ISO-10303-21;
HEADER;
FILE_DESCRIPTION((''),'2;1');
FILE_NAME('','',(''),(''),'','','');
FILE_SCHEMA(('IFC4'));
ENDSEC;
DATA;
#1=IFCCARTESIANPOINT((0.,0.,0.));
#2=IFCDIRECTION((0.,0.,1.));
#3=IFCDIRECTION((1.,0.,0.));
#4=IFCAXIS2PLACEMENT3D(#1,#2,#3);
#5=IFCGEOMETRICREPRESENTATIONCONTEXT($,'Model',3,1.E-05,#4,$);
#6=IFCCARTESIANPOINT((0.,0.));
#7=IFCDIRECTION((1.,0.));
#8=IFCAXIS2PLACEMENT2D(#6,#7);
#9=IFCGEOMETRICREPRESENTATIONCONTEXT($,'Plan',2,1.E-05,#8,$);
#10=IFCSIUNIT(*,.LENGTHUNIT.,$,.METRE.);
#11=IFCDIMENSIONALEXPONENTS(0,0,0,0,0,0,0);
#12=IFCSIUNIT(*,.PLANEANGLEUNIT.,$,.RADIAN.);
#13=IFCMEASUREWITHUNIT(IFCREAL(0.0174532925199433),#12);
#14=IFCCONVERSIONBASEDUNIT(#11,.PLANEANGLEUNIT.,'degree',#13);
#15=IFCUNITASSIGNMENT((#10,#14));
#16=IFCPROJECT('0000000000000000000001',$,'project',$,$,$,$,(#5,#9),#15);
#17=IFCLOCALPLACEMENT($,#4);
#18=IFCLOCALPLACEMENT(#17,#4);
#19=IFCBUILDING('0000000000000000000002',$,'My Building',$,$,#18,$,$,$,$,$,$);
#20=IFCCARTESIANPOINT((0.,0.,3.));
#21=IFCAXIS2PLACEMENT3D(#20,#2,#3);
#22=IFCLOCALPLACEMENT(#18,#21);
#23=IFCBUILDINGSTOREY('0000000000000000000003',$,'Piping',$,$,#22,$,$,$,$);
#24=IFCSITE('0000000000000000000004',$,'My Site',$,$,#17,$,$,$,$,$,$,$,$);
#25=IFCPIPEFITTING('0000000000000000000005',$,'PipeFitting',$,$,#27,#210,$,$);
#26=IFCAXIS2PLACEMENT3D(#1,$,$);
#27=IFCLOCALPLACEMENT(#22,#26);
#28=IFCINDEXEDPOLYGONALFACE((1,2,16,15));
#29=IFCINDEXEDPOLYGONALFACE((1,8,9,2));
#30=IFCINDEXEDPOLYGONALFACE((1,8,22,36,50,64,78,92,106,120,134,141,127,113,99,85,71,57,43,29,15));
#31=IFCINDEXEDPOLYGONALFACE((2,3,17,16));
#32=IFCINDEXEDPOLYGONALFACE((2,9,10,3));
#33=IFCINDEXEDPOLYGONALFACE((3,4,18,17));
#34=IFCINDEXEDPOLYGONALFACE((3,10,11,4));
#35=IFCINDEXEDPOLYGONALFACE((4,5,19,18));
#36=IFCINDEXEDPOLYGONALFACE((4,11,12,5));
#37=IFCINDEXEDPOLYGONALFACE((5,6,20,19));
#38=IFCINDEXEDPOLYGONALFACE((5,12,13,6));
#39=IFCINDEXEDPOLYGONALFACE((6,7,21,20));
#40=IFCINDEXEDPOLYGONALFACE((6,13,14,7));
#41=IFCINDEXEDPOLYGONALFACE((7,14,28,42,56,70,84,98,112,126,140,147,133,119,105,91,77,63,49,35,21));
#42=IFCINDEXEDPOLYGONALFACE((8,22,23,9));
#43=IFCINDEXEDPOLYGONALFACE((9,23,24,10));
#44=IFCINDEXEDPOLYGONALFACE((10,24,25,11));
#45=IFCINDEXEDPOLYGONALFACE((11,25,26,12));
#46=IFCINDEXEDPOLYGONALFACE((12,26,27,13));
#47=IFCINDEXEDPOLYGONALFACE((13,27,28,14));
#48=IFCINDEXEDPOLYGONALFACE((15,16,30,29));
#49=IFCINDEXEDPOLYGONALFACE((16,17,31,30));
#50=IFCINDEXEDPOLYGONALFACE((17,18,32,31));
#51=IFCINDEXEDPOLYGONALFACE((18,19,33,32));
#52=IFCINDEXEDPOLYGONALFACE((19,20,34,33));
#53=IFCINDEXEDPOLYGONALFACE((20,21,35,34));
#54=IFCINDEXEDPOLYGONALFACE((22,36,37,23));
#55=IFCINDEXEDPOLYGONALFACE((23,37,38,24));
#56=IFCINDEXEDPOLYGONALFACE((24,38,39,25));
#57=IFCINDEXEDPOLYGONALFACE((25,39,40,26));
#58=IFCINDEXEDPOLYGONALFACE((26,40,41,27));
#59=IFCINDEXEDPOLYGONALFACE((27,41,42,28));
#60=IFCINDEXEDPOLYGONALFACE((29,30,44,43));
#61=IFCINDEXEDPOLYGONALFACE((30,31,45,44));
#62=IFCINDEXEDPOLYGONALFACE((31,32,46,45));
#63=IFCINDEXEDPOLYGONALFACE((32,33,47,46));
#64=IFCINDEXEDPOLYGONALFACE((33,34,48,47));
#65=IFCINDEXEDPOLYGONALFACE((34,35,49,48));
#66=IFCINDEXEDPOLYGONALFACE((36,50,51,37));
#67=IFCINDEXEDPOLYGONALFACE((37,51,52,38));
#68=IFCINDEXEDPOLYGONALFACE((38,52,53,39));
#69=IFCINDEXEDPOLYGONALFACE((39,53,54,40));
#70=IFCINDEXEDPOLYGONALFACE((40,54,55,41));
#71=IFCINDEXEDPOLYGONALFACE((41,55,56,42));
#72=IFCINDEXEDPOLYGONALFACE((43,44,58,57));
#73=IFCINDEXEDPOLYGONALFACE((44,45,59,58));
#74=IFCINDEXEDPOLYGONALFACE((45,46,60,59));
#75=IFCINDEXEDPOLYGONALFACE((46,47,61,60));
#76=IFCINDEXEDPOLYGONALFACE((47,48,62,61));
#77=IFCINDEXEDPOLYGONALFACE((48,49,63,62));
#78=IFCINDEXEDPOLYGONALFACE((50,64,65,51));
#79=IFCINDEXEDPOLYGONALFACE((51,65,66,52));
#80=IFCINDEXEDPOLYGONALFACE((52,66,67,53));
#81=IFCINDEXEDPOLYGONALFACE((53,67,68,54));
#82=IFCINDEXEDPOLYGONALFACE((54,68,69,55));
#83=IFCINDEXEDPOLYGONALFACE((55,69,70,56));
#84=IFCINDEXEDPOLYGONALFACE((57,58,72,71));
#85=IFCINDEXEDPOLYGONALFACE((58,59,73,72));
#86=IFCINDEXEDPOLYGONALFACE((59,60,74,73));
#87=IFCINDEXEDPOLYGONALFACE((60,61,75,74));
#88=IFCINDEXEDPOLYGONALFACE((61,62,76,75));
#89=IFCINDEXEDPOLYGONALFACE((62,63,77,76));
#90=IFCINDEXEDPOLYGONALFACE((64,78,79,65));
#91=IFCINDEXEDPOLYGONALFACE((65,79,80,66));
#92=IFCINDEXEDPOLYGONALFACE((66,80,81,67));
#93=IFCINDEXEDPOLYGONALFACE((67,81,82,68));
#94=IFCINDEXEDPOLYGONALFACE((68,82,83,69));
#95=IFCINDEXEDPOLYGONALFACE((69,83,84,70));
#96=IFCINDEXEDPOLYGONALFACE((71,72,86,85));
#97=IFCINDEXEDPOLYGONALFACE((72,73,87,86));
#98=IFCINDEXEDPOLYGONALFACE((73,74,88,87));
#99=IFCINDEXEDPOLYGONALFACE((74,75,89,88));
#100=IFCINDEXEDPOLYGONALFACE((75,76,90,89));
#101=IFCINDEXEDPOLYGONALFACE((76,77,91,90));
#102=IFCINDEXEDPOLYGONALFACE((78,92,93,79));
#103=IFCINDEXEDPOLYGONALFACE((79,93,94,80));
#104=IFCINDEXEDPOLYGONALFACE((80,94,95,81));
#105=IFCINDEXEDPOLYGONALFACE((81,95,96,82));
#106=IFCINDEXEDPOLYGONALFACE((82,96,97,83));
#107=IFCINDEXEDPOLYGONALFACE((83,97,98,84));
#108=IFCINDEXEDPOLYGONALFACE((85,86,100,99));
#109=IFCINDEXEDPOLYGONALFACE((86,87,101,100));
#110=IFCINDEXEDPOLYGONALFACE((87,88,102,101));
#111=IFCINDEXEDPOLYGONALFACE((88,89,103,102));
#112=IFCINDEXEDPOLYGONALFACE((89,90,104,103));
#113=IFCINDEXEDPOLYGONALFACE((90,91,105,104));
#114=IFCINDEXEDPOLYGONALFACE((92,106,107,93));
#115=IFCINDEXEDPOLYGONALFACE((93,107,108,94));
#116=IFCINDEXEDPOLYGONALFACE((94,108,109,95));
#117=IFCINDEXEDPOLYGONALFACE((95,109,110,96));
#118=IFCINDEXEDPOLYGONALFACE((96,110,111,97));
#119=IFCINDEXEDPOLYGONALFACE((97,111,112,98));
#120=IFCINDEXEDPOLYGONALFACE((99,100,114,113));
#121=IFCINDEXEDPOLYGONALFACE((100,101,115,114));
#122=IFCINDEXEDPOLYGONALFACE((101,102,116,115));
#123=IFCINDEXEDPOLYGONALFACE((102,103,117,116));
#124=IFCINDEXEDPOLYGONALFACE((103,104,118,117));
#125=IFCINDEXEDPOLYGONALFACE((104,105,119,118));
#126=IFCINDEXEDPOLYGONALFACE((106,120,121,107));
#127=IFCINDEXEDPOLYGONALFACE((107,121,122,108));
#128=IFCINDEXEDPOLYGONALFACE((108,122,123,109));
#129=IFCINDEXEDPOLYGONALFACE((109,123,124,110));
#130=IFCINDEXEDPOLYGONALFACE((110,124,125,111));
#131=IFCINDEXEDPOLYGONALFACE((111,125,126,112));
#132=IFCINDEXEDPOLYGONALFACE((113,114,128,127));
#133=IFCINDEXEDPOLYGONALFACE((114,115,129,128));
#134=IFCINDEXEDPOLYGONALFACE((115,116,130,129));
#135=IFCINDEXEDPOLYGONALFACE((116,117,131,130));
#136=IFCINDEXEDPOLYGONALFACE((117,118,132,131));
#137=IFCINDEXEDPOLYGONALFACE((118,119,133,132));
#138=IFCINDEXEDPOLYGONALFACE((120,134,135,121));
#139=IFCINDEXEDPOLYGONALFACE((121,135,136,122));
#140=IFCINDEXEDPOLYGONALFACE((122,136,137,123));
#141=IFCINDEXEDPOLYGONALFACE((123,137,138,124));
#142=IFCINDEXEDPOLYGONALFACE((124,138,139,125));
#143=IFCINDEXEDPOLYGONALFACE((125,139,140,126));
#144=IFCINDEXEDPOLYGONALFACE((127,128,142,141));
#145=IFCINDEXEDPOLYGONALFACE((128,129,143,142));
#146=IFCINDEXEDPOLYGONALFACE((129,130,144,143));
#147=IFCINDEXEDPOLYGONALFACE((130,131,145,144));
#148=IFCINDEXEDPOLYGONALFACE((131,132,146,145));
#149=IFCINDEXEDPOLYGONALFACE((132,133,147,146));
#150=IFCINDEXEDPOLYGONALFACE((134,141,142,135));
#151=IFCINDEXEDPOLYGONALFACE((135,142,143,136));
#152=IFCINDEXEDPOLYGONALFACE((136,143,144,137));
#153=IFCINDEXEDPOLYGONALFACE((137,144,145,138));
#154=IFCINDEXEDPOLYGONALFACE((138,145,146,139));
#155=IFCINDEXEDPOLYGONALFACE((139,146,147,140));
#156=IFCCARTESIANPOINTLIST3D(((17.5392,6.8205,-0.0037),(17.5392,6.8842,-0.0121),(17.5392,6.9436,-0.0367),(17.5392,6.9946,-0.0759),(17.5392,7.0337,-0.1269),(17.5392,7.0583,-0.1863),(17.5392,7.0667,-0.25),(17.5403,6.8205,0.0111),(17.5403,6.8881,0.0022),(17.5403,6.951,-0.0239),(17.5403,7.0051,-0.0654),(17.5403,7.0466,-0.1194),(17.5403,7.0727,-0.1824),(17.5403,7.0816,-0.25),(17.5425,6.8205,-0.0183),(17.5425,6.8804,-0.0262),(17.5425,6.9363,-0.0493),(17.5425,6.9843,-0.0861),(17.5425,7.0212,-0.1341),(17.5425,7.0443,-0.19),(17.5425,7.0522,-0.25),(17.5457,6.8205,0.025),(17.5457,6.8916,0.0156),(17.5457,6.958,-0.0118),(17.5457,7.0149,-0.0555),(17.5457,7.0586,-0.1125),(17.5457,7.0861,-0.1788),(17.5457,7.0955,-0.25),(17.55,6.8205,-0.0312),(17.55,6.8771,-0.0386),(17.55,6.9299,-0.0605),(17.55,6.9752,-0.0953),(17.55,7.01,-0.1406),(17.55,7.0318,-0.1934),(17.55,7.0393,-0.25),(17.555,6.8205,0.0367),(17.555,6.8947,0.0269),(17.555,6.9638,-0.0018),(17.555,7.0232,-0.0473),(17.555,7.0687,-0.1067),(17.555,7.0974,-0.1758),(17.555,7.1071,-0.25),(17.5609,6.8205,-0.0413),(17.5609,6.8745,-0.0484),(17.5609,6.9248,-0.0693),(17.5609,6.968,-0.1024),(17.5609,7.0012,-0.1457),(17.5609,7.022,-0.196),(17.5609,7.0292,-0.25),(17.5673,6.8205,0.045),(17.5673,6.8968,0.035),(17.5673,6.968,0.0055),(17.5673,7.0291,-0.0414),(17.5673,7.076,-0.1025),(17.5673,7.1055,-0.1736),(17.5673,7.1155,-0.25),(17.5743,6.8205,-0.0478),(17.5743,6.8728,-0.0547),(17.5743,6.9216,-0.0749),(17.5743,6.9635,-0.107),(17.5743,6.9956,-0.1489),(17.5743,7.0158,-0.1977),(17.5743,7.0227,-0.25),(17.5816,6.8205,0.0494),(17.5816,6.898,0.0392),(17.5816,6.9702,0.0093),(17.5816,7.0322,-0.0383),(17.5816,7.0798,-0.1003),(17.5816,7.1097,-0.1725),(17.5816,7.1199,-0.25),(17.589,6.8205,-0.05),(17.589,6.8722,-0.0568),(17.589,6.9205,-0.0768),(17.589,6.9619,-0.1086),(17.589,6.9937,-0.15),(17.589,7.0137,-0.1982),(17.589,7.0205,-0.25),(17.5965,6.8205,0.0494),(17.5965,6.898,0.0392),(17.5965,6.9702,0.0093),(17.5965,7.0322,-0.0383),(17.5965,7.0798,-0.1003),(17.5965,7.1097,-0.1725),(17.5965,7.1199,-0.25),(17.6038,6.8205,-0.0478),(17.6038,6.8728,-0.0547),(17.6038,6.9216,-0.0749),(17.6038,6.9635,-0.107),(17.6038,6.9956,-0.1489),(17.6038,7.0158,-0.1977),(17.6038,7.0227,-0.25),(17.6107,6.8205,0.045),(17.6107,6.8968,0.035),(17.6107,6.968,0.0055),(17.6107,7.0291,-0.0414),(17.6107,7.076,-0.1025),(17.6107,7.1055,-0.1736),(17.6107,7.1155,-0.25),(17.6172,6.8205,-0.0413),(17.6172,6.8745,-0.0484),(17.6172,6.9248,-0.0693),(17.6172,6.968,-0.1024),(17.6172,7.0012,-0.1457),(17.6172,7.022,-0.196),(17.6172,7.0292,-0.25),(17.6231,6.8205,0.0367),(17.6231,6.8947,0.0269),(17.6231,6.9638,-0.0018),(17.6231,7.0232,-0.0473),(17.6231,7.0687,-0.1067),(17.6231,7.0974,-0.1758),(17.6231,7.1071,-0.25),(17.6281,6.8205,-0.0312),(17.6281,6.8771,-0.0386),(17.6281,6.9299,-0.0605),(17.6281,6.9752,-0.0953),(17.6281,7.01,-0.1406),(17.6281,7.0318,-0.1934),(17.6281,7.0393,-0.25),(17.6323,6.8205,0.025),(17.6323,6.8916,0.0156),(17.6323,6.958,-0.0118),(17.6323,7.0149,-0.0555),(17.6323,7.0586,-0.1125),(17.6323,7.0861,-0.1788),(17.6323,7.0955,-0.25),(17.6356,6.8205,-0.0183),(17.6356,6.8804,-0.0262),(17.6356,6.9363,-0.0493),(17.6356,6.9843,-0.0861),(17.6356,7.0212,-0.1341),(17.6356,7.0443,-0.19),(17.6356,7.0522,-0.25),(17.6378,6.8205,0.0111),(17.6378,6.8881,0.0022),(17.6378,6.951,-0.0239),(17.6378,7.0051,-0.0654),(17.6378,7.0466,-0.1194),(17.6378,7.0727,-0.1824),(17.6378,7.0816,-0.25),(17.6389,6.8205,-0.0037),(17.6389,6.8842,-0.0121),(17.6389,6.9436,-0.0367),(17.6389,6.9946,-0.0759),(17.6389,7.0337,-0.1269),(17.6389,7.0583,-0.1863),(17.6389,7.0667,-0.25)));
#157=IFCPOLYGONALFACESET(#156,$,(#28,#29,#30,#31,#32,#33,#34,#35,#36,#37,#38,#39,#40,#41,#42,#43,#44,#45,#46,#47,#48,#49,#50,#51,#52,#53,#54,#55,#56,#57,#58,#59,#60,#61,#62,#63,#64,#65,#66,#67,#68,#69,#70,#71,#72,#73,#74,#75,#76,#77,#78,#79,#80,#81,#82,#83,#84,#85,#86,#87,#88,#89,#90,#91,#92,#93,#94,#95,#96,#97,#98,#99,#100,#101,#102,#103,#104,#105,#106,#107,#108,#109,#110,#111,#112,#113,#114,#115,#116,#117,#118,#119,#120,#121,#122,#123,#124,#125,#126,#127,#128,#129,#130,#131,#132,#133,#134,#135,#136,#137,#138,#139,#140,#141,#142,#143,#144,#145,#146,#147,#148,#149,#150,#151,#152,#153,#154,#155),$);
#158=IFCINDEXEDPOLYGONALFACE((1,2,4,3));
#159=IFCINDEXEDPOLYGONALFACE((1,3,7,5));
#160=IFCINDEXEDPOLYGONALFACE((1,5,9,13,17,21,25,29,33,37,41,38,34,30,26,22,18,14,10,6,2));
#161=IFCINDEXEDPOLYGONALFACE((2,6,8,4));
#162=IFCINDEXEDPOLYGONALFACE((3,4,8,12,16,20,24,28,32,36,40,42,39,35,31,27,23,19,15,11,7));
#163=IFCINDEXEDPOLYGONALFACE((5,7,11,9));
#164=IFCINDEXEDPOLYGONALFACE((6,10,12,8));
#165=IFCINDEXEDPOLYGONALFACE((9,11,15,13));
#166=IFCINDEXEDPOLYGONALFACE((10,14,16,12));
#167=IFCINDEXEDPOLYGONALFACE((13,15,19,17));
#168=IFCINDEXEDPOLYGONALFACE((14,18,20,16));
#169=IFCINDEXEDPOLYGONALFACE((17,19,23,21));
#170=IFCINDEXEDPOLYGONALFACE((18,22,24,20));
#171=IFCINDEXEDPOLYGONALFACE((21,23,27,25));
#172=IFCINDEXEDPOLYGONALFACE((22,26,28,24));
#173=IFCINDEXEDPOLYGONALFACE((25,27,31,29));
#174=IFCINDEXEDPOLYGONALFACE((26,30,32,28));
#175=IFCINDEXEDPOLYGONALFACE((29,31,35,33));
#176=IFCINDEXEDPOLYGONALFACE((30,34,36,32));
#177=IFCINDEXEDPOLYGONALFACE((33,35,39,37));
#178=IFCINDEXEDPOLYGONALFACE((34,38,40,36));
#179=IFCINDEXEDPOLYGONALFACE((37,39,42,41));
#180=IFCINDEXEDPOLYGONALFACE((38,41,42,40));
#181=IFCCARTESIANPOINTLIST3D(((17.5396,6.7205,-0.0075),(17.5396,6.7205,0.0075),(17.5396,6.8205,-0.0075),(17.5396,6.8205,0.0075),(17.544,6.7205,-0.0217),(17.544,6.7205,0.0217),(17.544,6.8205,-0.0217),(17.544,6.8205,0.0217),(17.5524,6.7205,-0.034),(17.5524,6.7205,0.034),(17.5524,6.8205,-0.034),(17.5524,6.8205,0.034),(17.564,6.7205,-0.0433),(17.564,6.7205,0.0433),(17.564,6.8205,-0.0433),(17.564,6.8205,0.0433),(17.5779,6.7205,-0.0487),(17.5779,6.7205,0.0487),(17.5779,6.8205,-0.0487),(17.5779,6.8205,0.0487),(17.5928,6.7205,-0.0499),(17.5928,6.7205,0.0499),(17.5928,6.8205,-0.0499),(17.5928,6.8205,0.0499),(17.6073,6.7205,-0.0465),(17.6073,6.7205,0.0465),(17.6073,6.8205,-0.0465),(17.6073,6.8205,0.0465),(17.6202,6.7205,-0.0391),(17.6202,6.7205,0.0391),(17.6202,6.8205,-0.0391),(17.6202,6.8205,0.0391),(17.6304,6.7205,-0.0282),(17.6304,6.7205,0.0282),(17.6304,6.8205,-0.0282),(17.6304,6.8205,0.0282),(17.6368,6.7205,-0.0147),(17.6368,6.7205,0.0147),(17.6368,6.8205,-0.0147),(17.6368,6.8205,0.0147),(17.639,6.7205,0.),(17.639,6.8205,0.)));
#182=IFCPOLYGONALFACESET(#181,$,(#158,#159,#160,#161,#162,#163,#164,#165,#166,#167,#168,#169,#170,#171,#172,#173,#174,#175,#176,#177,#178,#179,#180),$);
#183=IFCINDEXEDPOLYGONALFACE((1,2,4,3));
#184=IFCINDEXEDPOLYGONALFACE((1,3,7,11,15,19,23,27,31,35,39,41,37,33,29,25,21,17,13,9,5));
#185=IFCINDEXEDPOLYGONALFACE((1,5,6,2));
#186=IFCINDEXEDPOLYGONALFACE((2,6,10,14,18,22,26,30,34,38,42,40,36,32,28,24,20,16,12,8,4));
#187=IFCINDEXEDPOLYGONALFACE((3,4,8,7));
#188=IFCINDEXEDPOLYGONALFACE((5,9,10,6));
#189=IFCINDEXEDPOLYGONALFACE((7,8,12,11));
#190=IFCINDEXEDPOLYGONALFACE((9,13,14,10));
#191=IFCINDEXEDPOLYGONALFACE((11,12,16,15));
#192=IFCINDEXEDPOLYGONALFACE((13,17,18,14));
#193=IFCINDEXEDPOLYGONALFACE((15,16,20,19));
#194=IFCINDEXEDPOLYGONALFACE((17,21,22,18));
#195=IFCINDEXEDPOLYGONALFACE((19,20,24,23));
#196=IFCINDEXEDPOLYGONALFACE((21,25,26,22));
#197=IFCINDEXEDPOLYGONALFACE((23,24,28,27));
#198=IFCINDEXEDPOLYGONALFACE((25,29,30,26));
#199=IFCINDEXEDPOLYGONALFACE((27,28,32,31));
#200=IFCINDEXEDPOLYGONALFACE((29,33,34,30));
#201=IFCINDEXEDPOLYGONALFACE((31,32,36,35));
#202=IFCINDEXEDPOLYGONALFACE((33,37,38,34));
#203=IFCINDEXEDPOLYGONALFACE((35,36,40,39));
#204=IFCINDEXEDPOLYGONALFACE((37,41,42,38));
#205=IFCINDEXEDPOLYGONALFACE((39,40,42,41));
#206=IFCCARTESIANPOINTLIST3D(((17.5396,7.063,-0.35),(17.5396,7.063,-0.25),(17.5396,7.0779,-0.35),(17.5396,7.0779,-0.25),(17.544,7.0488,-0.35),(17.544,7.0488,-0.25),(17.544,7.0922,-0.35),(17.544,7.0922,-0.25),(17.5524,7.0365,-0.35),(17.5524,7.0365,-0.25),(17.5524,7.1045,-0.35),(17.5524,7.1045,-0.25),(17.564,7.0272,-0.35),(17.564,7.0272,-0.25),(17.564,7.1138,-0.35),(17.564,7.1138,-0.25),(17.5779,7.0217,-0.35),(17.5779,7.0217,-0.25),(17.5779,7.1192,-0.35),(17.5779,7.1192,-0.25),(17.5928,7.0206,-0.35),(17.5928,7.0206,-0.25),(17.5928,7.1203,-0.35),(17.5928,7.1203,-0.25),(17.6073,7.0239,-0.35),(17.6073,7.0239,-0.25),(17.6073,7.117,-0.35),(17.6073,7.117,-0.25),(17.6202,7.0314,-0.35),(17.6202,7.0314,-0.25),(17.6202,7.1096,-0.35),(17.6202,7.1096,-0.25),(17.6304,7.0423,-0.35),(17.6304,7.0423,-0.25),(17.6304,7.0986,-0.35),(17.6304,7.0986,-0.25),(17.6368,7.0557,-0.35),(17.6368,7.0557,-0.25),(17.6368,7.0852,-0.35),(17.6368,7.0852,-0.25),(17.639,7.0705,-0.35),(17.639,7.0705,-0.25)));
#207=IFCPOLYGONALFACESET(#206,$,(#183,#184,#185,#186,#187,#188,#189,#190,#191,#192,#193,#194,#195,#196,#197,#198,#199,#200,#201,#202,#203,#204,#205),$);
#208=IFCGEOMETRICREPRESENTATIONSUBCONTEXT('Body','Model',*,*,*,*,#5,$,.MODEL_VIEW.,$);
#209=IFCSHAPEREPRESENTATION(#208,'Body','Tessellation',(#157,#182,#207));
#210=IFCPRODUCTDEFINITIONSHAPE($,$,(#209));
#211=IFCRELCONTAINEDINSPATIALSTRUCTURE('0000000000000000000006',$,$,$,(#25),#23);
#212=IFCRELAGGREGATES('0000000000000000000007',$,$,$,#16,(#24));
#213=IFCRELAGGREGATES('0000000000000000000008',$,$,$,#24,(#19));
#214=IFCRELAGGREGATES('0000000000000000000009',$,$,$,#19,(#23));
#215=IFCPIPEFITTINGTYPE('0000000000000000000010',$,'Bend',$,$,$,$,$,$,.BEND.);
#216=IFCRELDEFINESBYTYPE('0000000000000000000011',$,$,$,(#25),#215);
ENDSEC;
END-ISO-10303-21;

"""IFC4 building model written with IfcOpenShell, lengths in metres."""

from ifc_helpers import new_model, entity, si_unit, converted_unit, frame, origin_with_axes, origin_2d_with_axis, place, context, subcontext, project, spatial, circle, extrude, source, transform, mapped, type_object, type_shapes, element, save


model = new_model("IFC4")

# Units and contexts
model_context = context("Model", 3, precision=1e-05, world=origin_with_axes())
plan_context = context("Plan", 2, precision=1e-05, world=origin_2d_with_axis())
body_context = subcontext(model_context, "Body", "Model", "MODEL_VIEW")
ifc_project = project(units=[si_unit("LENGTHUNIT", "METRE"), converted_unit("PLANEANGLEUNIT", "degree", entity("IfcReal", 0.0174532925199433), si_unit("PLANEANGLEUNIT", "RADIAN"), dimensions=[0, 0, 0, 0, 0, 0, 0])], contexts=[model_context, plan_context])

# Site, building, storey
site_placement = place(None, origin_with_axes())
site = spatial("IfcSite", under=ifc_project, at=site_placement, Name="My Site")
building_placement = place(site_placement, origin_with_axes())
building = spatial("IfcBuilding", under=site, at=building_placement, Name="My Building")
storey_placement = place(building_placement, frame((0.0, 0.0, 3.0), z_axis=(0.0, 0.0, 1.0), x_axis=(1.0, 0.0, 0.0)))
storey = spatial("IfcBuildingStorey", under=building, at=storey_placement, Name="Piping")

# Pipe fitting
pipe_fitting_type = type_object("IfcPipeFittingType", Name="Bend", PredefinedType="BEND")
shared_shape = source(origin_with_axes(), body_context, "Body", "SolidModel", [
    entity("IfcSweptDiskSolid", entity("IfcIndexedPolyCurve", entity("IfcCartesianPointList3D", [[0.0, 0.0, -0.1], [0.0, -0.0732, -0.2768], [0.0, -0.25, -0.35]]), [entity("IfcArcIndex", [1, 2, 3])]), 0.05),
    extrude(circle(Radius=0.05), origin_with_axes(), (0.0, 0.0, -1.0), 0.1),
    extrude(circle(Radius=0.05), frame((0.0, -0.25, -0.35), z_axis=(0.0, -1.0, 0.0), x_axis=(1.0, 0.0, 0.0)), (0.0, 0.0, 1.0), 0.1),
])
type_shapes(pipe_fitting_type, [shared_shape])
for number, where, z_axis, x_axis, name in (
    (1, (17.589, 6.7205, 0.0), (0.0, -1.0, 0.0), (1.0, 0.0, 0.0), "PipeFitting"),
):
    element("IfcPipeFitting", number, at=place(storey_placement, frame(where, z_axis=z_axis, x_axis=x_axis)), inside=storey, type_object=pipe_fitting_type, Name=name, context=body_context, shape_type="MappedRepresentation", body=[
        mapped(shared_shape, transform((0.0, 0.0, 0.0), x_axis=(1.0, 0.0, 0.0), y_axis=(0.0, 1.0, 0.0), z_axis=(0.0, 0.0, 1.0), scale=1.0)),
    ])

save(model, "model.ifc")
